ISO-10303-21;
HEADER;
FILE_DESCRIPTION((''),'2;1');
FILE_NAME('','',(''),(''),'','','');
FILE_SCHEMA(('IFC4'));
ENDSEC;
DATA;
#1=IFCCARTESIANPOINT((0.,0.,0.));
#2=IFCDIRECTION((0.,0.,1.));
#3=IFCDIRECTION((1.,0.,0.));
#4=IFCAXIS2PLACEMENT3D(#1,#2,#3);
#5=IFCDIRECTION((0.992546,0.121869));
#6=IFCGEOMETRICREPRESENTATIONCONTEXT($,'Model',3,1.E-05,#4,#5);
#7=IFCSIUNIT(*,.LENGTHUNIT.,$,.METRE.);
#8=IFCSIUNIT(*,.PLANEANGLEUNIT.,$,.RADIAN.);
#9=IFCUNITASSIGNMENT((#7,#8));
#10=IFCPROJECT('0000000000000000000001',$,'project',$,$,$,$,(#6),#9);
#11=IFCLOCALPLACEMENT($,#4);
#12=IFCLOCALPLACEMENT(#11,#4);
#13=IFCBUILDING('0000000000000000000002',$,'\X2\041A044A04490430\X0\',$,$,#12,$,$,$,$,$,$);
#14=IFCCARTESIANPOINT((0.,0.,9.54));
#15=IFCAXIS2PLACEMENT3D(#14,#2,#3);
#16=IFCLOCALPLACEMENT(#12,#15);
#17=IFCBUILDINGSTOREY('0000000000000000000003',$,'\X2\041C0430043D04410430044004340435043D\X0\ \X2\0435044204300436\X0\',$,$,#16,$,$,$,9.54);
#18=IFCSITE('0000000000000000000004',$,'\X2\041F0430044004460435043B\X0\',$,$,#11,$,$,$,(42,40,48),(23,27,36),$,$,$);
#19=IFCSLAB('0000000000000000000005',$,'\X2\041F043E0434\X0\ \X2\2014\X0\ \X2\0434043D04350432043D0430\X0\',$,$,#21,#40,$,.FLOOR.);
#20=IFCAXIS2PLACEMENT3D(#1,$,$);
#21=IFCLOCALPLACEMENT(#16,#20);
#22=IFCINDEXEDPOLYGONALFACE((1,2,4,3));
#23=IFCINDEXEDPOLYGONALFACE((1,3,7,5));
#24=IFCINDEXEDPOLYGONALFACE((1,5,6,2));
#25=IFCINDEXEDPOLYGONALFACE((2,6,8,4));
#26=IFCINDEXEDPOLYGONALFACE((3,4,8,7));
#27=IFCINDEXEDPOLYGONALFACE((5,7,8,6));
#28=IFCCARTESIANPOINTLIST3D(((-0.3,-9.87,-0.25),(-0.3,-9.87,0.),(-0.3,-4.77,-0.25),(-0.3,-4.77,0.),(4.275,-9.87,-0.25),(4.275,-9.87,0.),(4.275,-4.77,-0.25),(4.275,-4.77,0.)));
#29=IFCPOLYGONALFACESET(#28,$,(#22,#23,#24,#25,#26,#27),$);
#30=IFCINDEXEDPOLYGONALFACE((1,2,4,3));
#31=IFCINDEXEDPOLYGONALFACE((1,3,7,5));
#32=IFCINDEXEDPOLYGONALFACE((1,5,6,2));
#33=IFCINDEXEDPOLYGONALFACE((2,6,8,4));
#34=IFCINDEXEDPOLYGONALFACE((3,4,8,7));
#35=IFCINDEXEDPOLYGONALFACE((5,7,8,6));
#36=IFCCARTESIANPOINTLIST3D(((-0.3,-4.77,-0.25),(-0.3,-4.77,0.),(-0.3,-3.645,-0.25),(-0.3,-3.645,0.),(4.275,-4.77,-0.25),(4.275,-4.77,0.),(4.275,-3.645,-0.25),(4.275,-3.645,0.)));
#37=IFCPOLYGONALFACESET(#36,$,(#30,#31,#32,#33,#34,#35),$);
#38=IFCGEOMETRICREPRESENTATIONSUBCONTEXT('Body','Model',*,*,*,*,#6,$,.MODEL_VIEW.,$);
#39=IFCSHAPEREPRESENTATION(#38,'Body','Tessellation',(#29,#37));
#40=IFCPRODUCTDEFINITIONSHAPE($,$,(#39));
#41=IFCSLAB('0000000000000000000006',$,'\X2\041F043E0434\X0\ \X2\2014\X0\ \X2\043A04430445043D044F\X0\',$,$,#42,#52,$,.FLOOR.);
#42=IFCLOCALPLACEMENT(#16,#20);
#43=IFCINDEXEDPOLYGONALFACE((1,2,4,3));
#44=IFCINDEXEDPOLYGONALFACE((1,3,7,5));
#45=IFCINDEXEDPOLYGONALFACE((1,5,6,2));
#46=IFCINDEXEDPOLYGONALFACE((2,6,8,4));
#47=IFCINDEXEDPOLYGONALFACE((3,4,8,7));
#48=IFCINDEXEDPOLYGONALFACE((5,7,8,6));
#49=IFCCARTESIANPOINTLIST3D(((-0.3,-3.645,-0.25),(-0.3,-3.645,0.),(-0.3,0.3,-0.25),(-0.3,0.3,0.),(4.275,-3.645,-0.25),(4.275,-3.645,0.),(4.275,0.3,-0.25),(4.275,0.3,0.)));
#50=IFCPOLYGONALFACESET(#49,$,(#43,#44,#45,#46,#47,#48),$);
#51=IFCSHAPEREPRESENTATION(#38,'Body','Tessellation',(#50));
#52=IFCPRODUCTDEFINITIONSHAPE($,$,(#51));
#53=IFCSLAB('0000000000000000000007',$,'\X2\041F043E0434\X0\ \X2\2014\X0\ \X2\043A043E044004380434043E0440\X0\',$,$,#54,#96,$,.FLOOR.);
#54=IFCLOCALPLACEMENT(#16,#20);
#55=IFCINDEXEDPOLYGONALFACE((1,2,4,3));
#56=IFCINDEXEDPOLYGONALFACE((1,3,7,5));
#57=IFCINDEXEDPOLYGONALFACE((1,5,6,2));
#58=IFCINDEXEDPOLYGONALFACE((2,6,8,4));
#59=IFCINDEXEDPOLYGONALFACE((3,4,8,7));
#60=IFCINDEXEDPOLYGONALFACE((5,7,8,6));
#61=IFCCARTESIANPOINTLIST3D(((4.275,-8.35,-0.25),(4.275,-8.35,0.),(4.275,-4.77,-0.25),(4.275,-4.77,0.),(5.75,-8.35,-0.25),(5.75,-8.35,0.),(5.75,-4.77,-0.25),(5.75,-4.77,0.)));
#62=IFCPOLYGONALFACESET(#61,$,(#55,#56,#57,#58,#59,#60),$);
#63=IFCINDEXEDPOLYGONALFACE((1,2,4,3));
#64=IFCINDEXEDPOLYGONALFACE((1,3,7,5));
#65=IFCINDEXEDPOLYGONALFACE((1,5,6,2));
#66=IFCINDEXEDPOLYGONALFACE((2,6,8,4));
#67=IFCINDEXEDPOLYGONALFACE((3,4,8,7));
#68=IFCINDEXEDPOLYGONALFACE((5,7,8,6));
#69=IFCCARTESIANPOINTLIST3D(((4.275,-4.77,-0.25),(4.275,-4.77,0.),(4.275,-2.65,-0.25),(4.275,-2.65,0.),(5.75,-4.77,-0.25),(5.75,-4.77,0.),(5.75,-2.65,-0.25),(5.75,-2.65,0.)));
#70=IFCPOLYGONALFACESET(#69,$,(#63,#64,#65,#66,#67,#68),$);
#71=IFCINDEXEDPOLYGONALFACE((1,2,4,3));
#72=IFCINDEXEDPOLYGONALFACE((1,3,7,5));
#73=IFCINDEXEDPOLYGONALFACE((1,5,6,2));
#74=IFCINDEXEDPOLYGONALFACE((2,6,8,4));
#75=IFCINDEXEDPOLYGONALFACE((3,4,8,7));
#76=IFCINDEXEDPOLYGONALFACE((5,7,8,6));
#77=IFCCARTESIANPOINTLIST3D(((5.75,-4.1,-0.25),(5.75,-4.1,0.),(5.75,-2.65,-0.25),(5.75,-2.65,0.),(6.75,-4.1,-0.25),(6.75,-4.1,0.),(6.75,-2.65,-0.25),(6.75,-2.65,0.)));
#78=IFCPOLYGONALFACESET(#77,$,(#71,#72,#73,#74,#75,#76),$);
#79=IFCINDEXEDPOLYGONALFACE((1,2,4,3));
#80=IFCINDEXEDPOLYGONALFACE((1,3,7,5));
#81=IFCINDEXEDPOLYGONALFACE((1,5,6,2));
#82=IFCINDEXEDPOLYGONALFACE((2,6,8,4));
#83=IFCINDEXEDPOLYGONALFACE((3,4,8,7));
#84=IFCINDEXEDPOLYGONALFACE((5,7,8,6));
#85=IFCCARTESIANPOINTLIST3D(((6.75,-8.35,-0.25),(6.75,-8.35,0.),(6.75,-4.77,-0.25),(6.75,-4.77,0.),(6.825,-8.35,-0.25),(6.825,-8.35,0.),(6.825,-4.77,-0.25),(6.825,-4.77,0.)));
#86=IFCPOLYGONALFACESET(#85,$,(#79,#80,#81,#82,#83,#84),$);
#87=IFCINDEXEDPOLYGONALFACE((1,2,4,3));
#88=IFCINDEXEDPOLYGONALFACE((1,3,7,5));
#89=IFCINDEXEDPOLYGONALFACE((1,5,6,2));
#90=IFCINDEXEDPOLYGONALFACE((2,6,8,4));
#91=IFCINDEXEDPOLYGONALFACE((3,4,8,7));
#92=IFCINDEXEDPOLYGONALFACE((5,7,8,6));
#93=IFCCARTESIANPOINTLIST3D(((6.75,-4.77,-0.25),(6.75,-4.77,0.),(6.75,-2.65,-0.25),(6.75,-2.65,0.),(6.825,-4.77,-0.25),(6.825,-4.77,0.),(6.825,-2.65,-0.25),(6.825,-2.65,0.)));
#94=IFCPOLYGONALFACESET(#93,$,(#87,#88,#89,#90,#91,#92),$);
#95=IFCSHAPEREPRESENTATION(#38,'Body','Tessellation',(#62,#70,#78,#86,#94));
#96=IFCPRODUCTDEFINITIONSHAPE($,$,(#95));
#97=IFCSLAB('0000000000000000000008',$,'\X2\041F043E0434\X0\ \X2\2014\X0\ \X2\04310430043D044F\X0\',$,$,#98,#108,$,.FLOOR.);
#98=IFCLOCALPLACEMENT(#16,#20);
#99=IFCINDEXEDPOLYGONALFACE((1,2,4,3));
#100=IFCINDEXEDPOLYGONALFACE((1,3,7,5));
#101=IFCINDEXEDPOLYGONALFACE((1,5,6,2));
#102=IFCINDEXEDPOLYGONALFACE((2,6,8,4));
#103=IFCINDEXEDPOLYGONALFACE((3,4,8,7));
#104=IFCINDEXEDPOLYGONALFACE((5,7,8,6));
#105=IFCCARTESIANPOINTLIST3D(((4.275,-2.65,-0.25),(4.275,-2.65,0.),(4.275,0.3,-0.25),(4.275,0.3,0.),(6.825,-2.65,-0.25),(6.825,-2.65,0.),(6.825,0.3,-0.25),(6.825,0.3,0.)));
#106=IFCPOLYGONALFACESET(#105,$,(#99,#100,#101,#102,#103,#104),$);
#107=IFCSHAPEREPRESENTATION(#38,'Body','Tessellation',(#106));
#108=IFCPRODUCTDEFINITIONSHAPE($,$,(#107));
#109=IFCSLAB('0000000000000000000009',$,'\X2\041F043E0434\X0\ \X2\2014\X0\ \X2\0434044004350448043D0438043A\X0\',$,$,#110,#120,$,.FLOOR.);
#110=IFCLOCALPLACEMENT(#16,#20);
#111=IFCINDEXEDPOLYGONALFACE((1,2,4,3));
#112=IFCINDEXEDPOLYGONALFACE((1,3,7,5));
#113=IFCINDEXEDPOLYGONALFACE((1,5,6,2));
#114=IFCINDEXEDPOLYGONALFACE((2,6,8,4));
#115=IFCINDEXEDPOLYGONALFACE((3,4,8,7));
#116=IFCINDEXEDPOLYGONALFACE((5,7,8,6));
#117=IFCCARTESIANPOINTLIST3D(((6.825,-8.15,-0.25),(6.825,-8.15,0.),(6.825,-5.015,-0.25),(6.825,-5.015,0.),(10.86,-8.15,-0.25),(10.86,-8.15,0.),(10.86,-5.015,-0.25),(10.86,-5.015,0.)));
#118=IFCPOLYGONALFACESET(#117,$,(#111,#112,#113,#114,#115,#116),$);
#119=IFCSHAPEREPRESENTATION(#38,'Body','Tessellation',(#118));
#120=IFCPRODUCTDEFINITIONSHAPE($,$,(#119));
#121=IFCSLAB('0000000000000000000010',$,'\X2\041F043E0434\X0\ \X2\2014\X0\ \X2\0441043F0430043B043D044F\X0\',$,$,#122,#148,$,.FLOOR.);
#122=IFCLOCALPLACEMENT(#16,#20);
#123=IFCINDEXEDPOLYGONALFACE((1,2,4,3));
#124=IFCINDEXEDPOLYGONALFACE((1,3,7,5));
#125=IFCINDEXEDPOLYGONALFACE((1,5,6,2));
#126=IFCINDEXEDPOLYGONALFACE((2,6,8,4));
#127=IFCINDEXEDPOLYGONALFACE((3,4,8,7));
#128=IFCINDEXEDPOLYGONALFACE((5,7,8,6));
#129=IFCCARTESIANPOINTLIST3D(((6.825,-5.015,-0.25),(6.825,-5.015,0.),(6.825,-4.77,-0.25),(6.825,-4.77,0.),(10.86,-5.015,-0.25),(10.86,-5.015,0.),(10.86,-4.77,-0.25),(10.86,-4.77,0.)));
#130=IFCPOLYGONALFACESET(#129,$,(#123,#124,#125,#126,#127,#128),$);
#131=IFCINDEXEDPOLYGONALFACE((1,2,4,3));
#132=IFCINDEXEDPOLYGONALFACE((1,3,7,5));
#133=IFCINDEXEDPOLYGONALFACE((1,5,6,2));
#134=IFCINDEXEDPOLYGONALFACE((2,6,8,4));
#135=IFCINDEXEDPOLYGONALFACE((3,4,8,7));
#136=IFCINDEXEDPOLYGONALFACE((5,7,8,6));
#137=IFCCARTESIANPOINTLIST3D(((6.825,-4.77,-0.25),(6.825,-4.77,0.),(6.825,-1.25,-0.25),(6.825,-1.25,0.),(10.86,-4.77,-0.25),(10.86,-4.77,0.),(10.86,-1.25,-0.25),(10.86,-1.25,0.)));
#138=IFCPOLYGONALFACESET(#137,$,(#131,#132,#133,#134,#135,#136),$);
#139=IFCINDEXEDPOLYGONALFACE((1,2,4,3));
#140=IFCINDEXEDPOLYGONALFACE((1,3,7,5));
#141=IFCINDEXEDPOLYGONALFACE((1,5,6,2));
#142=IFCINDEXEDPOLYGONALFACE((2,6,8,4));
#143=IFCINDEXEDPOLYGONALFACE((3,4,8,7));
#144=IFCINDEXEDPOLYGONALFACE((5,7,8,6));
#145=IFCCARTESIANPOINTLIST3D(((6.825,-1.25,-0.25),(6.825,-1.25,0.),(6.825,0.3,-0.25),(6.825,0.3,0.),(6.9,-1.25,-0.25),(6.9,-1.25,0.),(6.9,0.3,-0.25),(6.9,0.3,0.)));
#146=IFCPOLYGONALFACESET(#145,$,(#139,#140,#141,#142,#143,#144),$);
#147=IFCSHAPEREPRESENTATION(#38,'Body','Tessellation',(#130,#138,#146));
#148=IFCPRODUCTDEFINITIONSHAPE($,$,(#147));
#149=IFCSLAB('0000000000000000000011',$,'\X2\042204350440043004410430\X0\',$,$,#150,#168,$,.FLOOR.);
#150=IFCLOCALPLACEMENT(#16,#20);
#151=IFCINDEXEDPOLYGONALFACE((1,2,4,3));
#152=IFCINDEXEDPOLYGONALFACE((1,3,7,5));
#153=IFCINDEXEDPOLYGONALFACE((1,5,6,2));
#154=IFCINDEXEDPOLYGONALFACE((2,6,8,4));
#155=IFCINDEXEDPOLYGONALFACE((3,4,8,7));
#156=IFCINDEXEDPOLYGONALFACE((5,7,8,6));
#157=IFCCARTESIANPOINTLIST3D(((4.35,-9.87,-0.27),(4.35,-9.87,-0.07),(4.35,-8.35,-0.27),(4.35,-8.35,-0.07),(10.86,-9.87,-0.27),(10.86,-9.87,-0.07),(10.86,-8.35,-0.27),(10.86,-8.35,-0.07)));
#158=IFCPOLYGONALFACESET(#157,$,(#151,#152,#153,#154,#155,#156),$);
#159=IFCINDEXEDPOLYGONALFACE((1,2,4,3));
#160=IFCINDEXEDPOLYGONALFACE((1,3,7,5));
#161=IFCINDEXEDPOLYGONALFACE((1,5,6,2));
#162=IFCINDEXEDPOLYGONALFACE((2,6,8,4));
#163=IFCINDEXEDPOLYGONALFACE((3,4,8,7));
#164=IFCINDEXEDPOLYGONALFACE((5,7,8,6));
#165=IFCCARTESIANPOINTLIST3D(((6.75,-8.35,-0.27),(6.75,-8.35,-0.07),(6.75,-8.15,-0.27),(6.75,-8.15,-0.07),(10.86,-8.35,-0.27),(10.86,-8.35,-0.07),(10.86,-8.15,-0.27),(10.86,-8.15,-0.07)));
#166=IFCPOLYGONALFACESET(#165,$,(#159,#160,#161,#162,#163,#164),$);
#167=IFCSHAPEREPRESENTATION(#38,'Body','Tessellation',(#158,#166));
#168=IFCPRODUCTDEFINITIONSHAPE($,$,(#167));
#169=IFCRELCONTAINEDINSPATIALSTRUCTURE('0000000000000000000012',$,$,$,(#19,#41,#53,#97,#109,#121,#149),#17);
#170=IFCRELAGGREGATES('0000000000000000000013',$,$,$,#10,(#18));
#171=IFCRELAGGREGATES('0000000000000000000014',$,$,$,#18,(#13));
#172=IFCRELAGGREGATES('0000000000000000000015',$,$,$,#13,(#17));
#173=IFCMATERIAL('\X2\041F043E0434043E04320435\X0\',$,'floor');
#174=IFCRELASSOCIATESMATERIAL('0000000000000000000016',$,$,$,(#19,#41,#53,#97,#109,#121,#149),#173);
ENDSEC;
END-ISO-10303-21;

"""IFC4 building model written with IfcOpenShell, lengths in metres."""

from ifc_helpers import new_model, si_unit, direction, frame, origin_with_axes, place, context, subcontext, project, spatial, polyline, outline, extrude, material, element, save


model = new_model("IFC4")

# Units and contexts
model_context = context("Model", 3, precision=1e-05, world=origin_with_axes(), true_north=direction((0.992546, 0.121869)))
body_context = subcontext(model_context, "Body", "Model", "MODEL_VIEW")
ifc_project = project(units=[si_unit("LENGTHUNIT", "METRE"), si_unit("PLANEANGLEUNIT", "RADIAN")], contexts=[model_context])

# Site, building, storey
site_placement = place(None, origin_with_axes())
site = spatial("IfcSite", under=ifc_project, at=site_placement, Name="Парцел", RefLatitude=(42, 40, 48), RefLongitude=(23, 27, 36))
building_placement = place(site_placement, origin_with_axes())
building = spatial("IfcBuilding", under=site, at=building_placement, Name="Къща")
storey_placement = place(building_placement, frame((0.0, 0.0, 9.54), z_axis=(0.0, 0.0, 1.0), x_axis=(1.0, 0.0, 0.0)))
storey = spatial("IfcBuildingStorey", under=building, at=storey_placement, Name="Мансарден етаж", Elevation=9.54)

# Slabs
ifc_material_1 = material(Name="Подове", Category="floor")
slab_1_placement = place(storey_placement, origin_with_axes())
element("IfcSlab", 1, at=slab_1_placement, inside=storey, material=ifc_material_1, Name="Под — дневна", PredefinedType="FLOOR", context=body_context, shape_type="SweptSolid", body=[
    extrude(outline(polyline([(-0.3, 0.25), (4.275, 0.25), (4.275, 0.0), (-0.3, 0.0), (-0.3, 0.25)])), frame((0.0, -9.87, 0.0), z_axis=(0.0, 1.0, 0.0), x_axis=(1.0, 0.0, 0.0)), (0.0, 0.0, 1.0), 5.1),
    extrude(outline(polyline([(-0.3, 0.25), (4.275, 0.25), (4.275, 0.0), (-0.3, 0.0), (-0.3, 0.25)])), frame((0.0, -4.77, 0.0), z_axis=(0.0, 1.0, 0.0), x_axis=(1.0, 0.0, 0.0)), (0.0, 0.0, 1.0), 1.125),
])
slab_2_placement = place(storey_placement, origin_with_axes())
element("IfcSlab", 2, at=slab_2_placement, inside=storey, material=ifc_material_1, Name="Под — кухня", PredefinedType="FLOOR", context=body_context, shape_type="SweptSolid", body=[
    extrude(outline(polyline([(-0.3, 0.25), (4.275, 0.25), (4.275, 0.0), (-0.3, 0.0), (-0.3, 0.25)])), frame((0.0, -3.645, 0.0), z_axis=(0.0, 1.0, 0.0), x_axis=(1.0, 0.0, 0.0)), (0.0, 0.0, 1.0), 3.945),
])
slab_3_placement = place(storey_placement, origin_with_axes())
element("IfcSlab", 3, at=slab_3_placement, inside=storey, material=ifc_material_1, Name="Под — коридор", PredefinedType="FLOOR", context=body_context, shape_type="SweptSolid", body=[
    extrude(outline(polyline([(4.275, 0.25), (5.75, 0.25), (5.75, 0.0), (4.275, 0.0), (4.275, 0.25)])), frame((0.0, -8.35, 0.0), z_axis=(0.0, 1.0, 0.0), x_axis=(1.0, 0.0, 0.0)), (0.0, 0.0, 1.0), 3.58),
    extrude(outline(polyline([(4.275, 0.25), (5.75, 0.25), (5.75, 0.0), (4.275, 0.0), (4.275, 0.25)])), frame((0.0, -4.77, 0.0), z_axis=(0.0, 1.0, 0.0), x_axis=(1.0, 0.0, 0.0)), (0.0, 0.0, 1.0), 2.12),
    extrude(outline(polyline([(5.75, 0.25), (6.75, 0.25), (6.75, 0.0), (5.75, 0.0), (5.75, 0.25)])), frame((0.0, -4.1, 0.0), z_axis=(0.0, 1.0, 0.0), x_axis=(1.0, 0.0, 0.0)), (0.0, 0.0, 1.0), 1.45),
    extrude(outline(polyline([(6.75, 0.25), (6.825, 0.25), (6.825, 0.0), (6.75, 0.0), (6.75, 0.25)])), frame((0.0, -8.35, 0.0), z_axis=(0.0, 1.0, 0.0), x_axis=(1.0, 0.0, 0.0)), (0.0, 0.0, 1.0), 3.58),
    extrude(outline(polyline([(6.75, 0.25), (6.825, 0.25), (6.825, 0.0), (6.75, 0.0), (6.75, 0.25)])), frame((0.0, -4.77, 0.0), z_axis=(0.0, 1.0, 0.0), x_axis=(1.0, 0.0, 0.0)), (0.0, 0.0, 1.0), 2.12),
])
slab_4_placement = place(storey_placement, origin_with_axes())
element("IfcSlab", 4, at=slab_4_placement, inside=storey, material=ifc_material_1, Name="Под — баня", PredefinedType="FLOOR", context=body_context, shape_type="SweptSolid", body=[
    extrude(outline(polyline([(4.275, 0.25), (6.825, 0.25), (6.825, 0.0), (4.275, 0.0), (4.275, 0.25)])), frame((0.0, -2.65, 0.0), z_axis=(0.0, 1.0, 0.0), x_axis=(1.0, 0.0, 0.0)), (0.0, 0.0, 1.0), 2.95),
])
slab_5_placement = place(storey_placement, origin_with_axes())
element("IfcSlab", 5, at=slab_5_placement, inside=storey, material=ifc_material_1, Name="Под — дрешник", PredefinedType="FLOOR", context=body_context, shape_type="SweptSolid", body=[
    extrude(outline(polyline([(6.825, 0.25), (10.86, 0.25), (10.86, 0.0), (6.825, 0.0), (6.825, 0.25)])), frame((0.0, -8.15, 0.0), z_axis=(0.0, 1.0, 0.0), x_axis=(1.0, 0.0, 0.0)), (0.0, 0.0, 1.0), 3.135),
])
slab_6_placement = place(storey_placement, origin_with_axes())
element("IfcSlab", 6, at=slab_6_placement, inside=storey, material=ifc_material_1, Name="Под — спалня", PredefinedType="FLOOR", context=body_context, shape_type="SweptSolid", body=[
    extrude(outline(polyline([(6.825, 0.25), (10.86, 0.25), (10.86, 0.0), (6.825, 0.0), (6.825, 0.25)])), frame((0.0, -5.015, 0.0), z_axis=(0.0, 1.0, 0.0), x_axis=(1.0, 0.0, 0.0)), (0.0, 0.0, 1.0), 0.245),
    extrude(outline(polyline([(6.825, 0.25), (10.86, 0.25), (10.86, 0.0), (6.825, 0.0), (6.825, 0.25)])), frame((0.0, -4.77, 0.0), z_axis=(0.0, 1.0, 0.0), x_axis=(1.0, 0.0, 0.0)), (0.0, 0.0, 1.0), 3.52),
    extrude(outline(polyline([(6.825, 0.25), (6.9, 0.25), (6.9, 0.0), (6.825, 0.0), (6.825, 0.25)])), frame((0.0, -1.25, 0.0), z_axis=(0.0, 1.0, 0.0), x_axis=(1.0, 0.0, 0.0)), (0.0, 0.0, 1.0), 1.55),
])
slab_7_placement = place(storey_placement, origin_with_axes())
element("IfcSlab", 7, at=slab_7_placement, inside=storey, material=ifc_material_1, Name="Тераса", PredefinedType="FLOOR", context=body_context, shape_type="SweptSolid", body=[
    extrude(outline(polyline([(4.35, 0.27), (10.86, 0.27), (10.86, 0.07), (4.35, 0.07), (4.35, 0.27)])), frame((0.0, -9.87, 0.0), z_axis=(0.0, 1.0, 0.0), x_axis=(1.0, 0.0, 0.0)), (0.0, 0.0, 1.0), 1.52),
    extrude(outline(polyline([(6.75, 0.27), (10.86, 0.27), (10.86, 0.07), (6.75, 0.07), (6.75, 0.27)])), frame((0.0, -8.35, 0.0), z_axis=(0.0, 1.0, 0.0), x_axis=(1.0, 0.0, 0.0)), (0.0, 0.0, 1.0), 0.2),
])

save(model, "model.ifc")
